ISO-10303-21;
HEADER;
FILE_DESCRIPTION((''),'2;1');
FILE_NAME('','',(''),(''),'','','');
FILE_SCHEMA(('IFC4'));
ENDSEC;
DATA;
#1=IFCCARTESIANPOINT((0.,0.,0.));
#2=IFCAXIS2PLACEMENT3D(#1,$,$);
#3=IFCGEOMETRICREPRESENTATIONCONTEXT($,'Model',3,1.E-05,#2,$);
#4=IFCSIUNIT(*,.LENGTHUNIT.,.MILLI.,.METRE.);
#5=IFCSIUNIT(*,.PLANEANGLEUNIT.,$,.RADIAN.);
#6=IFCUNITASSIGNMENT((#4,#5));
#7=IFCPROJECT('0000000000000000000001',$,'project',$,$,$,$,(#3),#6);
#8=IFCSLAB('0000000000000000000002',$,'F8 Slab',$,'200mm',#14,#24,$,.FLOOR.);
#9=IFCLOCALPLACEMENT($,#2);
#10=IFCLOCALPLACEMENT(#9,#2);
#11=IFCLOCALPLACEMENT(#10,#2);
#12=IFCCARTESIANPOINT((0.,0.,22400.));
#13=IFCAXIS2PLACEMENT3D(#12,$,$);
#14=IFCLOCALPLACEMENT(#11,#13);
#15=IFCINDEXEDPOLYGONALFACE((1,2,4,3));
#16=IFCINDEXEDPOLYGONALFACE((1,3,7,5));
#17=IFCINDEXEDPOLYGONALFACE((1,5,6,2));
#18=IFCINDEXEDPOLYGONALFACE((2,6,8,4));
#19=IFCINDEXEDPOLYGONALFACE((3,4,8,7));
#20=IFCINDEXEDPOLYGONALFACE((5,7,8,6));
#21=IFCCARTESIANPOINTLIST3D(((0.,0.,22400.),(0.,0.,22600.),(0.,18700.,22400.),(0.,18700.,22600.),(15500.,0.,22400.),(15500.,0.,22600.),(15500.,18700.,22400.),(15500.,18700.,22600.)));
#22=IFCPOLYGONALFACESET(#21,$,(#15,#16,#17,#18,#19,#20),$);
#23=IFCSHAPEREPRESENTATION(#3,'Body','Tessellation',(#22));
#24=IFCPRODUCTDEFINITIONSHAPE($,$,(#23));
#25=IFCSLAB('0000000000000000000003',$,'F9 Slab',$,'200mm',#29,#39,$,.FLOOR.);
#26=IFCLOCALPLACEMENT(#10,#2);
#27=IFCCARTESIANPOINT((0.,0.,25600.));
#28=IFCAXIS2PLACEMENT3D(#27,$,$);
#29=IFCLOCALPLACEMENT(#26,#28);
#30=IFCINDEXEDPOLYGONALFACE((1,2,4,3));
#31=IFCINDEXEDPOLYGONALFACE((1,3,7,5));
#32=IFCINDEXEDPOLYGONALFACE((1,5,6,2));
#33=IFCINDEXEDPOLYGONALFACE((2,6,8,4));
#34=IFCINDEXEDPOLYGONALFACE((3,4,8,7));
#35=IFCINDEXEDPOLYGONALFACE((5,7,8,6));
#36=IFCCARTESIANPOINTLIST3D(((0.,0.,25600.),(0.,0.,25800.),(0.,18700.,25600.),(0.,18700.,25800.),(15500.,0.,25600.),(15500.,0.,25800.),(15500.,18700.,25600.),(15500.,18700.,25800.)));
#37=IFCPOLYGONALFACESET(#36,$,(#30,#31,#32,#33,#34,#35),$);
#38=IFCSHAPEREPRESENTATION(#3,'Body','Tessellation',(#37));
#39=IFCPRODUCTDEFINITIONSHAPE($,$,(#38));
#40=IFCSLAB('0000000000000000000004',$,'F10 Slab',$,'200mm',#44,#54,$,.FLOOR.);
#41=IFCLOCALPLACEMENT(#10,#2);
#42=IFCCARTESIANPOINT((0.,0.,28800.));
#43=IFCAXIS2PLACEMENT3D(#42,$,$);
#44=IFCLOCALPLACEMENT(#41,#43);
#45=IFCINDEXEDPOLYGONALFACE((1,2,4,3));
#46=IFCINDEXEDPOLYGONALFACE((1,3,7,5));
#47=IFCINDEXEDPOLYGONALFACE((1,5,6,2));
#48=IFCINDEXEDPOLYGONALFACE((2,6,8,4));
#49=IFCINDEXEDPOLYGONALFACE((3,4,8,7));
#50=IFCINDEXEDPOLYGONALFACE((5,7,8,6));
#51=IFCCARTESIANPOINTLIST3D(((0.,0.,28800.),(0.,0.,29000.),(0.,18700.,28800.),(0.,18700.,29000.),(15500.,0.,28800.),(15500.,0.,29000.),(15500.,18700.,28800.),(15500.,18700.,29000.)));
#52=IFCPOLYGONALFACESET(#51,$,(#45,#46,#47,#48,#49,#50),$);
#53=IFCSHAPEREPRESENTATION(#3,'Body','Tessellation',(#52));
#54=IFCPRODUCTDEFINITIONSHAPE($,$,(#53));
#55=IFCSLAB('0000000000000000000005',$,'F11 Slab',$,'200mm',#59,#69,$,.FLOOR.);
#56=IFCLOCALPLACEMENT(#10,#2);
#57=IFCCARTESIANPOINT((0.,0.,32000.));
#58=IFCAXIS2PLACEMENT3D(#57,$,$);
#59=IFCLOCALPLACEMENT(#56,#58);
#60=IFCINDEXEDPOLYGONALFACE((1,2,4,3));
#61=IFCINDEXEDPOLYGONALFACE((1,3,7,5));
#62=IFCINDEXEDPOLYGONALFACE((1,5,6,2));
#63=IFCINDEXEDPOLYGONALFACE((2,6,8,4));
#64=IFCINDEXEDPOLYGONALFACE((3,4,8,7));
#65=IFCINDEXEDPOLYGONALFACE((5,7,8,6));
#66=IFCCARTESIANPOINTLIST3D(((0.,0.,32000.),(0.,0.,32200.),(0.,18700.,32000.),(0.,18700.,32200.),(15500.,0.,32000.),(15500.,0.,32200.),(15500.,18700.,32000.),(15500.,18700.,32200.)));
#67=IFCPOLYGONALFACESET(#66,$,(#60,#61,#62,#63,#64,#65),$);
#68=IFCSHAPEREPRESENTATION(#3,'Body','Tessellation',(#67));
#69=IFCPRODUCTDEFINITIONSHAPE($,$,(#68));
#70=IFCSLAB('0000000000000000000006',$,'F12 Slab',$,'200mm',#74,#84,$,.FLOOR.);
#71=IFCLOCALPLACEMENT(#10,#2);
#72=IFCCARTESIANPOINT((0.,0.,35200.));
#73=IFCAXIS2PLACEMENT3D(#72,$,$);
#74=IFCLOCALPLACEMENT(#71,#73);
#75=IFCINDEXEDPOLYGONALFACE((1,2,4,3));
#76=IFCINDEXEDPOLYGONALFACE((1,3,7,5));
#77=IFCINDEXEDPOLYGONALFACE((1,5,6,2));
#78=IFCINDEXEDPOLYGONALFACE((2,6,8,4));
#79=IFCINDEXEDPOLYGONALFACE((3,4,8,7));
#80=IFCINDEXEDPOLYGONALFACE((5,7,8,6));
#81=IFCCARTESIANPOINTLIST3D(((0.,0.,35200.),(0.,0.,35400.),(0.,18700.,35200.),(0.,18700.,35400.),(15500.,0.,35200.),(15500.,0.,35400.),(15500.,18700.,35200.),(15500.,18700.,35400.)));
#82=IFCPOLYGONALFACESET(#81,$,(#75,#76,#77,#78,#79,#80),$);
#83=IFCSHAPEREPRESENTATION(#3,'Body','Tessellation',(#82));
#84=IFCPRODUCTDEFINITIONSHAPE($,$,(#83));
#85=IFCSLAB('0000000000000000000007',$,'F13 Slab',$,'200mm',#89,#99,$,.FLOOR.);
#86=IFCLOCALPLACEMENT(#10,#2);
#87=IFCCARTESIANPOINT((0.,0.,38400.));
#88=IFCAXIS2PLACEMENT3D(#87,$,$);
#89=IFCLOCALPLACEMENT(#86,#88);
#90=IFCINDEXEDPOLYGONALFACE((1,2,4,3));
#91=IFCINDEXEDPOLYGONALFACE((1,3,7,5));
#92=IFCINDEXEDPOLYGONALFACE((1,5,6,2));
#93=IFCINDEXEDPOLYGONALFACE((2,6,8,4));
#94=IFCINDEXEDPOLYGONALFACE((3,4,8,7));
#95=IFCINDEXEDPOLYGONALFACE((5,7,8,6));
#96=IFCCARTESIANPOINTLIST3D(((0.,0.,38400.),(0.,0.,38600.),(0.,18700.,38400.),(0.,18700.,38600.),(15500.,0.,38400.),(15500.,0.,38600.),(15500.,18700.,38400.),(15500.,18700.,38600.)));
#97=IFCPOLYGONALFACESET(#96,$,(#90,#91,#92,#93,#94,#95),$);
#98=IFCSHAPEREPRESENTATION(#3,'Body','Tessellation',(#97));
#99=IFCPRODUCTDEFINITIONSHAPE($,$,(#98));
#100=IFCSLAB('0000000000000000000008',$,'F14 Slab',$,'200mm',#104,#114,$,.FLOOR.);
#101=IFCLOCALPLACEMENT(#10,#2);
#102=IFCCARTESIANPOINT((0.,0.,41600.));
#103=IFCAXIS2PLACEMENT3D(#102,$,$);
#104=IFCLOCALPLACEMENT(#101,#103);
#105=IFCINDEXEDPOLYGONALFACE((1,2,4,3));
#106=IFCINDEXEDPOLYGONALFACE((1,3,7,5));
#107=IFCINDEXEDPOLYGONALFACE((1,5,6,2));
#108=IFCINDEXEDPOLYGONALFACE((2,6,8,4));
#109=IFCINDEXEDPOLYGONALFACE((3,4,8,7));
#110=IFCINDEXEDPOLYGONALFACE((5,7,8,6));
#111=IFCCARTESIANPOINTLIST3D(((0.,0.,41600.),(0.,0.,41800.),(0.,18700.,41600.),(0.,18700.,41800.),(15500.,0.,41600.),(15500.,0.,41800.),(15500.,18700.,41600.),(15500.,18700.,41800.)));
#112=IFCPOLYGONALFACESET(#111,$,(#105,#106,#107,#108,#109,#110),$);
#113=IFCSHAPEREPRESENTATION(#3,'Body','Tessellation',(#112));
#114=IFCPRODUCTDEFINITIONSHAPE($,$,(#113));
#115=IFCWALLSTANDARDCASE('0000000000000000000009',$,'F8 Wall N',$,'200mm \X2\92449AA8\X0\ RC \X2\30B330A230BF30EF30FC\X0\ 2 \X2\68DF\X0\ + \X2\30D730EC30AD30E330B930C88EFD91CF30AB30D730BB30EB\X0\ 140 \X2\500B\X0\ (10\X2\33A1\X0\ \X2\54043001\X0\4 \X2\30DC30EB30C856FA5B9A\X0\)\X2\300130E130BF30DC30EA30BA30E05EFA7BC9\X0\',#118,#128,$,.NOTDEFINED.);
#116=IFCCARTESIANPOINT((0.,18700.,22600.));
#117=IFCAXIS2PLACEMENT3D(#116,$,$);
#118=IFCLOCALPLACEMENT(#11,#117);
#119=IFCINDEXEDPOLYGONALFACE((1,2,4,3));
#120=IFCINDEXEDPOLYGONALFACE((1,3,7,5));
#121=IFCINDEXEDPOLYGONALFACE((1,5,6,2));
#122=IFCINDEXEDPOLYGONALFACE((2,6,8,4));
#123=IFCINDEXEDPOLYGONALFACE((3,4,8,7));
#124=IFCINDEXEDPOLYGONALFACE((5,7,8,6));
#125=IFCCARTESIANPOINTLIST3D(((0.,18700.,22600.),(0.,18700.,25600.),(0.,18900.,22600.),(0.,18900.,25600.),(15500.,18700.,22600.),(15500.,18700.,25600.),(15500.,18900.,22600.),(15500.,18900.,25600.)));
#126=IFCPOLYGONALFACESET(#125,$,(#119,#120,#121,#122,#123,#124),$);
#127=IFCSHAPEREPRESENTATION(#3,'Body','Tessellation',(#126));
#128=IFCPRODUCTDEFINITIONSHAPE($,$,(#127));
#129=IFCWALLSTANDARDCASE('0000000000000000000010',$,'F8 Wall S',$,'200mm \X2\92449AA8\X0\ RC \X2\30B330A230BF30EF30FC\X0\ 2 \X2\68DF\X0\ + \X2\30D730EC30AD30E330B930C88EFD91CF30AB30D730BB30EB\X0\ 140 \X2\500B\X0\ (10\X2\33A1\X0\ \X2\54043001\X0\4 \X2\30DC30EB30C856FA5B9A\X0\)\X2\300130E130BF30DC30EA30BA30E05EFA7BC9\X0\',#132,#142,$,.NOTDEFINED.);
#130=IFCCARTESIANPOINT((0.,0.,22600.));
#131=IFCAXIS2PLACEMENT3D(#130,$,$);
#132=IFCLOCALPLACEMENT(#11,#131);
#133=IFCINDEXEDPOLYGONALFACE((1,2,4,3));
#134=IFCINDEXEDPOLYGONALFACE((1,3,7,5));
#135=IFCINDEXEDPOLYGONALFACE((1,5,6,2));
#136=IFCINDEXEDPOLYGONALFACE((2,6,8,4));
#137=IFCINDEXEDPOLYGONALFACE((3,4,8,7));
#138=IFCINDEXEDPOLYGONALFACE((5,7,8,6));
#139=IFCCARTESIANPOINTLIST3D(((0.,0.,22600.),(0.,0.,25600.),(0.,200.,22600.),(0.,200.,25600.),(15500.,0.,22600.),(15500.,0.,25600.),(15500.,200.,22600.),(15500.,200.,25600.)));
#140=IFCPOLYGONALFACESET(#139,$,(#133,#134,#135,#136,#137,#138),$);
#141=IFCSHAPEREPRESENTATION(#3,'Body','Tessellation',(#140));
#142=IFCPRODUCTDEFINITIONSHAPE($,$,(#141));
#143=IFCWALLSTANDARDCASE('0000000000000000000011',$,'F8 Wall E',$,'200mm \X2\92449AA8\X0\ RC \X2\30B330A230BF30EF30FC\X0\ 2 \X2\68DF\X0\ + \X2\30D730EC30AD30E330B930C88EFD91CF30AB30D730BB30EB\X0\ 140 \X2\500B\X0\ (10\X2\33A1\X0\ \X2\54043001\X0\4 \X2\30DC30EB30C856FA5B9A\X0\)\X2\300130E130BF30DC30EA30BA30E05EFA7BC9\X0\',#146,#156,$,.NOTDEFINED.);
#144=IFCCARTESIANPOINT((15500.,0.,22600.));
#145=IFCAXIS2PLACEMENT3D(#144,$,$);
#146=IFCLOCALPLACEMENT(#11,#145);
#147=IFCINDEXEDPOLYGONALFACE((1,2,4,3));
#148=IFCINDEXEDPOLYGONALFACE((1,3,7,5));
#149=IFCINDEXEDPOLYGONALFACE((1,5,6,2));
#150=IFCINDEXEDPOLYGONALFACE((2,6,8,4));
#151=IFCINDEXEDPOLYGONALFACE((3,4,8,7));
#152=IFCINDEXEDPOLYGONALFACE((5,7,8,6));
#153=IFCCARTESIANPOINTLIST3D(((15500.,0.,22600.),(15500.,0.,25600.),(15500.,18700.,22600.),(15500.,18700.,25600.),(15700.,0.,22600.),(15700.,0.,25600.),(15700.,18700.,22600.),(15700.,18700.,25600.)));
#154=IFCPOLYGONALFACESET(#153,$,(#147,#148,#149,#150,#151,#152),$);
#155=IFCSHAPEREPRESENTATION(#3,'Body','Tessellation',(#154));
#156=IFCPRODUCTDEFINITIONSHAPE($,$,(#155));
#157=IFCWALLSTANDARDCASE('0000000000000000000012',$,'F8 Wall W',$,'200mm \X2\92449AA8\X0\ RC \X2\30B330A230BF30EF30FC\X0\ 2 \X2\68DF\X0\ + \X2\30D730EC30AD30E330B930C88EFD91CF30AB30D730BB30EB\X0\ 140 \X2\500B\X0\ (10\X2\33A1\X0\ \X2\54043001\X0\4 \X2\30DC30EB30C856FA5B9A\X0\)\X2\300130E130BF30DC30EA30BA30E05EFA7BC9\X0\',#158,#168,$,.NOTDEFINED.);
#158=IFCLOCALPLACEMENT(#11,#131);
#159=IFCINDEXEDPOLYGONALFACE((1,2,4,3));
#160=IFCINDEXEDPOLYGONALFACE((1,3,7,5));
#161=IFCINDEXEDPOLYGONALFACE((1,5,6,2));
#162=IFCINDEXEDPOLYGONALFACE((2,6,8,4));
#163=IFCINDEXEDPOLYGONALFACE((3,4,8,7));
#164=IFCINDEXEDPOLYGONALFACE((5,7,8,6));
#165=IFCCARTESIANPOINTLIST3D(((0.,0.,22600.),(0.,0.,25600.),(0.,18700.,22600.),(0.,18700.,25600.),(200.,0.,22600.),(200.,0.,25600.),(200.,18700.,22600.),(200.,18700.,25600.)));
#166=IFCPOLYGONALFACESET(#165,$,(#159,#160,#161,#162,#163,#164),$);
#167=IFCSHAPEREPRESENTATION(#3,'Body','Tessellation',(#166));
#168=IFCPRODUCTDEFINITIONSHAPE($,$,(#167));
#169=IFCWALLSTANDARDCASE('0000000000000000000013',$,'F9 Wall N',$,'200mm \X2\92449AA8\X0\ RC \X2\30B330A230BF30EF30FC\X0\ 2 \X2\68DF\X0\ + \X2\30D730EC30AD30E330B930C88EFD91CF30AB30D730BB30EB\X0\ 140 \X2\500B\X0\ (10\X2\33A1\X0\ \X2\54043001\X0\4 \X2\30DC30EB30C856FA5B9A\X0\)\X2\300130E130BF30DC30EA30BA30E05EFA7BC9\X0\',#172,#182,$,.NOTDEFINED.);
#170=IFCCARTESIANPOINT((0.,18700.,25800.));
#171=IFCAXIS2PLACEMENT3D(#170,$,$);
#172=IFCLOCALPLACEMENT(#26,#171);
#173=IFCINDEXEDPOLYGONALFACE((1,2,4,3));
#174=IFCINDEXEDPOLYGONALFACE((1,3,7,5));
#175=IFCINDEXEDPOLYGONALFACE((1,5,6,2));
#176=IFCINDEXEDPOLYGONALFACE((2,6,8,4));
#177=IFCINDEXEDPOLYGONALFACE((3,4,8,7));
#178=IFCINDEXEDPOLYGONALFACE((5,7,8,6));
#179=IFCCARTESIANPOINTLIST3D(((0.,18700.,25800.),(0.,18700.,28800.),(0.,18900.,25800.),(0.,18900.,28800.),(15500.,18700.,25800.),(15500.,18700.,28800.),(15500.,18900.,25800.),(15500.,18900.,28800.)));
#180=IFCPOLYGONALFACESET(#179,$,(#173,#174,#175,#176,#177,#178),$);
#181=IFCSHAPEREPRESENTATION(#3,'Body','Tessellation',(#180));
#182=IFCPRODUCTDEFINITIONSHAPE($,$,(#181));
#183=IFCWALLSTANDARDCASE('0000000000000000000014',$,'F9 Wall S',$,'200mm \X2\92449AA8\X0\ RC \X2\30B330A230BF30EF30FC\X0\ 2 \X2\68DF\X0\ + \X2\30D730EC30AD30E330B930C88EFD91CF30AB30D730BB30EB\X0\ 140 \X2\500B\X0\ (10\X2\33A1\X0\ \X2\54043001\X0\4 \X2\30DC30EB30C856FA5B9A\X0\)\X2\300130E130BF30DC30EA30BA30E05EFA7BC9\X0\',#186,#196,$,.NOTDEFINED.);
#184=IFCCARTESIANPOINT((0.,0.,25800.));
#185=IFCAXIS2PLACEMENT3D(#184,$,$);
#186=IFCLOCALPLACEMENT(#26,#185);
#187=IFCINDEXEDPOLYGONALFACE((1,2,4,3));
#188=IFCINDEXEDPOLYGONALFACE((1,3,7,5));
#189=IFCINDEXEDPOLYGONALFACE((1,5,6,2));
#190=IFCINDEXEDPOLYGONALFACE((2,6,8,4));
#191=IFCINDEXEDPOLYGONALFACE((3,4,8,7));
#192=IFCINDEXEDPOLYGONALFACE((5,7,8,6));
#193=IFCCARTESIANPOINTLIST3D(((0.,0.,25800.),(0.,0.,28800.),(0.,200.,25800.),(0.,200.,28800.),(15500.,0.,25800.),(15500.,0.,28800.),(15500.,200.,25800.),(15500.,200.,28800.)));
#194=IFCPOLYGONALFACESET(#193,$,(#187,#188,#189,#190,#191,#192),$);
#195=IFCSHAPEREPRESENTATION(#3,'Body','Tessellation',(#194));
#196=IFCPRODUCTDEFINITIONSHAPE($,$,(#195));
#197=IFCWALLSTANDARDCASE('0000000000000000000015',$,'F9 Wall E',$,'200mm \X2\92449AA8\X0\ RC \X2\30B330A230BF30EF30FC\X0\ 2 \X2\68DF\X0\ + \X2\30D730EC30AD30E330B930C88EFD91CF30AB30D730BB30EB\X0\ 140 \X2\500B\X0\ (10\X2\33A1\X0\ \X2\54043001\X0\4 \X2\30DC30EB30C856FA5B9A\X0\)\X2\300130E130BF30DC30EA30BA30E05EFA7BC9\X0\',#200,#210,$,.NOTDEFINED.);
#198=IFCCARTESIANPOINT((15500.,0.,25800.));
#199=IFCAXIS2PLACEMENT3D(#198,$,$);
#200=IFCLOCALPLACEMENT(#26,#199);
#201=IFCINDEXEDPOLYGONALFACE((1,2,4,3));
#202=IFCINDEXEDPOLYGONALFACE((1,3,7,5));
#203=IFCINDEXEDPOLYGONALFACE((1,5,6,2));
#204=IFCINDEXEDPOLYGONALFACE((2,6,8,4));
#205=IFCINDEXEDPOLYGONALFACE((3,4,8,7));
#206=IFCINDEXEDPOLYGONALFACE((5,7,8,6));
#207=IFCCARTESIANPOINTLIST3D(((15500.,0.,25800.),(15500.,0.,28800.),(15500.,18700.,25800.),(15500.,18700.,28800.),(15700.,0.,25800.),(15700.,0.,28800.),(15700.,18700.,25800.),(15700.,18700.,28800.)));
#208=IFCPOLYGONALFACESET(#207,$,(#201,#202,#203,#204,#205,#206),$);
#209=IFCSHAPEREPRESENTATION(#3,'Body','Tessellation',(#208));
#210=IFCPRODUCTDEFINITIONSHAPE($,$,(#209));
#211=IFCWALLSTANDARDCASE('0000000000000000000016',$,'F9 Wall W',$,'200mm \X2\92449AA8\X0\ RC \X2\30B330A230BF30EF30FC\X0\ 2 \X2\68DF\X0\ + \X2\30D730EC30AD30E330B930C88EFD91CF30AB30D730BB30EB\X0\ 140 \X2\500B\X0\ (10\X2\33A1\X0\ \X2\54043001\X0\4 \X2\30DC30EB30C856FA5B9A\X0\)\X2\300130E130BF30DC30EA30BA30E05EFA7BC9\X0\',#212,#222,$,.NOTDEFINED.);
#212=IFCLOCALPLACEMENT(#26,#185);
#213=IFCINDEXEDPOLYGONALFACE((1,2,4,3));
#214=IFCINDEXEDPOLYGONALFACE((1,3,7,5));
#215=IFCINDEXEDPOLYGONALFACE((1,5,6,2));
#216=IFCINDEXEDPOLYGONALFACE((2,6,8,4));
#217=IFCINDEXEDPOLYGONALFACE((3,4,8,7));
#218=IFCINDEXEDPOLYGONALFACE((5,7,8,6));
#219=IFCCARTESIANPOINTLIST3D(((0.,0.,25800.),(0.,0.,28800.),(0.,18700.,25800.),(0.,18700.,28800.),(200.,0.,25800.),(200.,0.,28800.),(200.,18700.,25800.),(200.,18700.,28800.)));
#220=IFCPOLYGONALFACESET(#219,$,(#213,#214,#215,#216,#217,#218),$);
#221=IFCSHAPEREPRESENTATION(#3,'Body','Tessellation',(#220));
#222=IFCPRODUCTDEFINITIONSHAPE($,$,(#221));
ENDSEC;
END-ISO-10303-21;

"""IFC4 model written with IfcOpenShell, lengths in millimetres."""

from ifc_helpers import new_model, si_unit, frame, frame_2d, origin, place, context, project, rectangle, extrude, element, save


model = new_model("IFC4")

# Units and contexts
model_context = context("Model", 3, precision=1e-05, world=origin())
ifc_project = project(units=[si_unit("LENGTHUNIT", "METRE", prefix="MILLI"), si_unit("PLANEANGLEUNIT", "RADIAN")], contexts=[model_context])

# Slabs
placement_1 = place(None, origin())
placement_2 = place(placement_1, origin())
placement_3 = place(placement_2, origin())
slab_1_placement = place(placement_3, frame((0.0, 0.0, 22400.0)))
element("IfcSlab", 1, at=slab_1_placement, Name="F8 Slab", ObjectType="200mm", PredefinedType="FLOOR", context=model_context, shape_type="SweptSolid", body=[
    extrude(rectangle(XDim=15500.0, YDim=18700.0, at=frame_2d((7750.0, 9350.0))), frame((0.0, 0.0, 22400.0)), (0.0, 0.0, 1.0), 200.0),
])
placement_4 = place(placement_2, origin())
slab_2_placement = place(placement_4, frame((0.0, 0.0, 25600.0)))
element("IfcSlab", 2, at=slab_2_placement, Name="F9 Slab", ObjectType="200mm", PredefinedType="FLOOR", context=model_context, shape_type="SweptSolid", body=[
    extrude(rectangle(XDim=15500.0, YDim=18700.0, at=frame_2d((7750.0, 9350.0))), frame((0.0, 0.0, 25600.0)), (0.0, 0.0, 1.0), 200.0),
])
placement_5 = place(placement_2, origin())
slab_3_placement = place(placement_5, frame((0.0, 0.0, 28800.0)))
element("IfcSlab", 3, at=slab_3_placement, Name="F10 Slab", ObjectType="200mm", PredefinedType="FLOOR", context=model_context, shape_type="SweptSolid", body=[
    extrude(rectangle(XDim=15500.0, YDim=18700.0, at=frame_2d((7750.0, 9350.0))), frame((0.0, 0.0, 28800.0)), (0.0, 0.0, 1.0), 200.0),
])
placement_6 = place(placement_2, origin())
slab_4_placement = place(placement_6, frame((0.0, 0.0, 32000.0)))
element("IfcSlab", 4, at=slab_4_placement, Name="F11 Slab", ObjectType="200mm", PredefinedType="FLOOR", context=model_context, shape_type="SweptSolid", body=[
    extrude(rectangle(XDim=15500.0, YDim=18700.0, at=frame_2d((7750.0, 9350.0))), frame((0.0, 0.0, 32000.0)), (0.0, 0.0, 1.0), 200.0),
])
placement_7 = place(placement_2, origin())
slab_5_placement = place(placement_7, frame((0.0, 0.0, 35200.0)))
element("IfcSlab", 5, at=slab_5_placement, Name="F12 Slab", ObjectType="200mm", PredefinedType="FLOOR", context=model_context, shape_type="SweptSolid", body=[
    extrude(rectangle(XDim=15500.0, YDim=18700.0, at=frame_2d((7750.0, 9350.0))), frame((0.0, 0.0, 35200.0)), (0.0, 0.0, 1.0), 200.0),
])
placement_8 = place(placement_2, origin())
slab_6_placement = place(placement_8, frame((0.0, 0.0, 38400.0)))
element("IfcSlab", 6, at=slab_6_placement, Name="F13 Slab", ObjectType="200mm", PredefinedType="FLOOR", context=model_context, shape_type="SweptSolid", body=[
    extrude(rectangle(XDim=15500.0, YDim=18700.0, at=frame_2d((7750.0, 9350.0))), frame((0.0, 0.0, 38400.0)), (0.0, 0.0, 1.0), 200.0),
])
placement_9 = place(placement_2, origin())
slab_7_placement = place(placement_9, frame((0.0, 0.0, 41600.0)))
element("IfcSlab", 7, at=slab_7_placement, Name="F14 Slab", ObjectType="200mm", PredefinedType="FLOOR", context=model_context, shape_type="SweptSolid", body=[
    extrude(rectangle(XDim=15500.0, YDim=18700.0, at=frame_2d((7750.0, 9350.0))), frame((0.0, 0.0, 41600.0)), (0.0, 0.0, 1.0), 200.0),
])

# Walls
wall_1_placement = place(placement_3, frame((0.0, 18700.0, 22600.0)))
element("IfcWallStandardCase", 8, at=wall_1_placement, Name="F8 Wall N", ObjectType="200mm 鉄骨 RC コアタワー 2 棟 + プレキャスト軽量カプセル 140 個 (10㎡ 各、4 ボルト固定)、メタボリズム建築", PredefinedType="NOTDEFINED", context=model_context, shape_type="SweptSolid", body=[
    extrude(rectangle(XDim=15500.0, YDim=200.0, at=frame_2d((7750.0, 100.0))), frame((0.0, 18700.0, 22600.0)), (0.0, 0.0, 1.0), 3000.0),
])
wall_2_placement = place(placement_3, frame((0.0, 0.0, 22600.0)))
element("IfcWallStandardCase", 9, at=wall_2_placement, Name="F8 Wall S", ObjectType="200mm 鉄骨 RC コアタワー 2 棟 + プレキャスト軽量カプセル 140 個 (10㎡ 各、4 ボルト固定)、メタボリズム建築", PredefinedType="NOTDEFINED", context=model_context, shape_type="SweptSolid", body=[
    extrude(rectangle(XDim=15500.0, YDim=200.0, at=frame_2d((7750.0, 100.0))), frame((0.0, 0.0, 22600.0)), (0.0, 0.0, 1.0), 3000.0),
])
wall_3_placement = place(placement_3, frame((15500.0, 0.0, 22600.0)))
element("IfcWallStandardCase", 10, at=wall_3_placement, Name="F8 Wall E", ObjectType="200mm 鉄骨 RC コアタワー 2 棟 + プレキャスト軽量カプセル 140 個 (10㎡ 各、4 ボルト固定)、メタボリズム建築", PredefinedType="NOTDEFINED", context=model_context, shape_type="SweptSolid", body=[
    extrude(rectangle(XDim=200.0, YDim=18700.0, at=frame_2d((100.0, 9350.0))), frame((15500.0, 0.0, 22600.0)), (0.0, 0.0, 1.0), 3000.0),
])
wall_4_placement = place(placement_3, frame((0.0, 0.0, 22600.0)))
element("IfcWallStandardCase", 11, at=wall_4_placement, Name="F8 Wall W", ObjectType="200mm 鉄骨 RC コアタワー 2 棟 + プレキャスト軽量カプセル 140 個 (10㎡ 各、4 ボルト固定)、メタボリズム建築", PredefinedType="NOTDEFINED", context=model_context, shape_type="SweptSolid", body=[
    extrude(rectangle(XDim=200.0, YDim=18700.0, at=frame_2d((100.0, 9350.0))), frame((0.0, 0.0, 22600.0)), (0.0, 0.0, 1.0), 3000.0),
])
wall_5_placement = place(placement_4, frame((0.0, 18700.0, 25800.0)))
element("IfcWallStandardCase", 12, at=wall_5_placement, Name="F9 Wall N", ObjectType="200mm 鉄骨 RC コアタワー 2 棟 + プレキャスト軽量カプセル 140 個 (10㎡ 各、4 ボルト固定)、メタボリズム建築", PredefinedType="NOTDEFINED", context=model_context, shape_type="SweptSolid", body=[
    extrude(rectangle(XDim=15500.0, YDim=200.0, at=frame_2d((7750.0, 100.0))), frame((0.0, 18700.0, 25800.0)), (0.0, 0.0, 1.0), 3000.0),
])
wall_6_placement = place(placement_4, frame((0.0, 0.0, 25800.0)))
element("IfcWallStandardCase", 13, at=wall_6_placement, Name="F9 Wall S", ObjectType="200mm 鉄骨 RC コアタワー 2 棟 + プレキャスト軽量カプセル 140 個 (10㎡ 各、4 ボルト固定)、メタボリズム建築", PredefinedType="NOTDEFINED", context=model_context, shape_type="SweptSolid", body=[
    extrude(rectangle(XDim=15500.0, YDim=200.0, at=frame_2d((7750.0, 100.0))), frame((0.0, 0.0, 25800.0)), (0.0, 0.0, 1.0), 3000.0),
])
wall_7_placement = place(placement_4, frame((15500.0, 0.0, 25800.0)))
element("IfcWallStandardCase", 14, at=wall_7_placement, Name="F9 Wall E", ObjectType="200mm 鉄骨 RC コアタワー 2 棟 + プレキャスト軽量カプセル 140 個 (10㎡ 各、4 ボルト固定)、メタボリズム建築", PredefinedType="NOTDEFINED", context=model_context, shape_type="SweptSolid", body=[
    extrude(rectangle(XDim=200.0, YDim=18700.0, at=frame_2d((100.0, 9350.0))), frame((15500.0, 0.0, 25800.0)), (0.0, 0.0, 1.0), 3000.0),
])
wall_8_placement = place(placement_4, frame((0.0, 0.0, 25800.0)))
element("IfcWallStandardCase", 15, at=wall_8_placement, Name="F9 Wall W", ObjectType="200mm 鉄骨 RC コアタワー 2 棟 + プレキャスト軽量カプセル 140 個 (10㎡ 各、4 ボルト固定)、メタボリズム建築", PredefinedType="NOTDEFINED", context=model_context, shape_type="SweptSolid", body=[
    extrude(rectangle(XDim=200.0, YDim=18700.0, at=frame_2d((100.0, 9350.0))), frame((0.0, 0.0, 25800.0)), (0.0, 0.0, 1.0), 3000.0),
])

save(model, "model.ifc")
